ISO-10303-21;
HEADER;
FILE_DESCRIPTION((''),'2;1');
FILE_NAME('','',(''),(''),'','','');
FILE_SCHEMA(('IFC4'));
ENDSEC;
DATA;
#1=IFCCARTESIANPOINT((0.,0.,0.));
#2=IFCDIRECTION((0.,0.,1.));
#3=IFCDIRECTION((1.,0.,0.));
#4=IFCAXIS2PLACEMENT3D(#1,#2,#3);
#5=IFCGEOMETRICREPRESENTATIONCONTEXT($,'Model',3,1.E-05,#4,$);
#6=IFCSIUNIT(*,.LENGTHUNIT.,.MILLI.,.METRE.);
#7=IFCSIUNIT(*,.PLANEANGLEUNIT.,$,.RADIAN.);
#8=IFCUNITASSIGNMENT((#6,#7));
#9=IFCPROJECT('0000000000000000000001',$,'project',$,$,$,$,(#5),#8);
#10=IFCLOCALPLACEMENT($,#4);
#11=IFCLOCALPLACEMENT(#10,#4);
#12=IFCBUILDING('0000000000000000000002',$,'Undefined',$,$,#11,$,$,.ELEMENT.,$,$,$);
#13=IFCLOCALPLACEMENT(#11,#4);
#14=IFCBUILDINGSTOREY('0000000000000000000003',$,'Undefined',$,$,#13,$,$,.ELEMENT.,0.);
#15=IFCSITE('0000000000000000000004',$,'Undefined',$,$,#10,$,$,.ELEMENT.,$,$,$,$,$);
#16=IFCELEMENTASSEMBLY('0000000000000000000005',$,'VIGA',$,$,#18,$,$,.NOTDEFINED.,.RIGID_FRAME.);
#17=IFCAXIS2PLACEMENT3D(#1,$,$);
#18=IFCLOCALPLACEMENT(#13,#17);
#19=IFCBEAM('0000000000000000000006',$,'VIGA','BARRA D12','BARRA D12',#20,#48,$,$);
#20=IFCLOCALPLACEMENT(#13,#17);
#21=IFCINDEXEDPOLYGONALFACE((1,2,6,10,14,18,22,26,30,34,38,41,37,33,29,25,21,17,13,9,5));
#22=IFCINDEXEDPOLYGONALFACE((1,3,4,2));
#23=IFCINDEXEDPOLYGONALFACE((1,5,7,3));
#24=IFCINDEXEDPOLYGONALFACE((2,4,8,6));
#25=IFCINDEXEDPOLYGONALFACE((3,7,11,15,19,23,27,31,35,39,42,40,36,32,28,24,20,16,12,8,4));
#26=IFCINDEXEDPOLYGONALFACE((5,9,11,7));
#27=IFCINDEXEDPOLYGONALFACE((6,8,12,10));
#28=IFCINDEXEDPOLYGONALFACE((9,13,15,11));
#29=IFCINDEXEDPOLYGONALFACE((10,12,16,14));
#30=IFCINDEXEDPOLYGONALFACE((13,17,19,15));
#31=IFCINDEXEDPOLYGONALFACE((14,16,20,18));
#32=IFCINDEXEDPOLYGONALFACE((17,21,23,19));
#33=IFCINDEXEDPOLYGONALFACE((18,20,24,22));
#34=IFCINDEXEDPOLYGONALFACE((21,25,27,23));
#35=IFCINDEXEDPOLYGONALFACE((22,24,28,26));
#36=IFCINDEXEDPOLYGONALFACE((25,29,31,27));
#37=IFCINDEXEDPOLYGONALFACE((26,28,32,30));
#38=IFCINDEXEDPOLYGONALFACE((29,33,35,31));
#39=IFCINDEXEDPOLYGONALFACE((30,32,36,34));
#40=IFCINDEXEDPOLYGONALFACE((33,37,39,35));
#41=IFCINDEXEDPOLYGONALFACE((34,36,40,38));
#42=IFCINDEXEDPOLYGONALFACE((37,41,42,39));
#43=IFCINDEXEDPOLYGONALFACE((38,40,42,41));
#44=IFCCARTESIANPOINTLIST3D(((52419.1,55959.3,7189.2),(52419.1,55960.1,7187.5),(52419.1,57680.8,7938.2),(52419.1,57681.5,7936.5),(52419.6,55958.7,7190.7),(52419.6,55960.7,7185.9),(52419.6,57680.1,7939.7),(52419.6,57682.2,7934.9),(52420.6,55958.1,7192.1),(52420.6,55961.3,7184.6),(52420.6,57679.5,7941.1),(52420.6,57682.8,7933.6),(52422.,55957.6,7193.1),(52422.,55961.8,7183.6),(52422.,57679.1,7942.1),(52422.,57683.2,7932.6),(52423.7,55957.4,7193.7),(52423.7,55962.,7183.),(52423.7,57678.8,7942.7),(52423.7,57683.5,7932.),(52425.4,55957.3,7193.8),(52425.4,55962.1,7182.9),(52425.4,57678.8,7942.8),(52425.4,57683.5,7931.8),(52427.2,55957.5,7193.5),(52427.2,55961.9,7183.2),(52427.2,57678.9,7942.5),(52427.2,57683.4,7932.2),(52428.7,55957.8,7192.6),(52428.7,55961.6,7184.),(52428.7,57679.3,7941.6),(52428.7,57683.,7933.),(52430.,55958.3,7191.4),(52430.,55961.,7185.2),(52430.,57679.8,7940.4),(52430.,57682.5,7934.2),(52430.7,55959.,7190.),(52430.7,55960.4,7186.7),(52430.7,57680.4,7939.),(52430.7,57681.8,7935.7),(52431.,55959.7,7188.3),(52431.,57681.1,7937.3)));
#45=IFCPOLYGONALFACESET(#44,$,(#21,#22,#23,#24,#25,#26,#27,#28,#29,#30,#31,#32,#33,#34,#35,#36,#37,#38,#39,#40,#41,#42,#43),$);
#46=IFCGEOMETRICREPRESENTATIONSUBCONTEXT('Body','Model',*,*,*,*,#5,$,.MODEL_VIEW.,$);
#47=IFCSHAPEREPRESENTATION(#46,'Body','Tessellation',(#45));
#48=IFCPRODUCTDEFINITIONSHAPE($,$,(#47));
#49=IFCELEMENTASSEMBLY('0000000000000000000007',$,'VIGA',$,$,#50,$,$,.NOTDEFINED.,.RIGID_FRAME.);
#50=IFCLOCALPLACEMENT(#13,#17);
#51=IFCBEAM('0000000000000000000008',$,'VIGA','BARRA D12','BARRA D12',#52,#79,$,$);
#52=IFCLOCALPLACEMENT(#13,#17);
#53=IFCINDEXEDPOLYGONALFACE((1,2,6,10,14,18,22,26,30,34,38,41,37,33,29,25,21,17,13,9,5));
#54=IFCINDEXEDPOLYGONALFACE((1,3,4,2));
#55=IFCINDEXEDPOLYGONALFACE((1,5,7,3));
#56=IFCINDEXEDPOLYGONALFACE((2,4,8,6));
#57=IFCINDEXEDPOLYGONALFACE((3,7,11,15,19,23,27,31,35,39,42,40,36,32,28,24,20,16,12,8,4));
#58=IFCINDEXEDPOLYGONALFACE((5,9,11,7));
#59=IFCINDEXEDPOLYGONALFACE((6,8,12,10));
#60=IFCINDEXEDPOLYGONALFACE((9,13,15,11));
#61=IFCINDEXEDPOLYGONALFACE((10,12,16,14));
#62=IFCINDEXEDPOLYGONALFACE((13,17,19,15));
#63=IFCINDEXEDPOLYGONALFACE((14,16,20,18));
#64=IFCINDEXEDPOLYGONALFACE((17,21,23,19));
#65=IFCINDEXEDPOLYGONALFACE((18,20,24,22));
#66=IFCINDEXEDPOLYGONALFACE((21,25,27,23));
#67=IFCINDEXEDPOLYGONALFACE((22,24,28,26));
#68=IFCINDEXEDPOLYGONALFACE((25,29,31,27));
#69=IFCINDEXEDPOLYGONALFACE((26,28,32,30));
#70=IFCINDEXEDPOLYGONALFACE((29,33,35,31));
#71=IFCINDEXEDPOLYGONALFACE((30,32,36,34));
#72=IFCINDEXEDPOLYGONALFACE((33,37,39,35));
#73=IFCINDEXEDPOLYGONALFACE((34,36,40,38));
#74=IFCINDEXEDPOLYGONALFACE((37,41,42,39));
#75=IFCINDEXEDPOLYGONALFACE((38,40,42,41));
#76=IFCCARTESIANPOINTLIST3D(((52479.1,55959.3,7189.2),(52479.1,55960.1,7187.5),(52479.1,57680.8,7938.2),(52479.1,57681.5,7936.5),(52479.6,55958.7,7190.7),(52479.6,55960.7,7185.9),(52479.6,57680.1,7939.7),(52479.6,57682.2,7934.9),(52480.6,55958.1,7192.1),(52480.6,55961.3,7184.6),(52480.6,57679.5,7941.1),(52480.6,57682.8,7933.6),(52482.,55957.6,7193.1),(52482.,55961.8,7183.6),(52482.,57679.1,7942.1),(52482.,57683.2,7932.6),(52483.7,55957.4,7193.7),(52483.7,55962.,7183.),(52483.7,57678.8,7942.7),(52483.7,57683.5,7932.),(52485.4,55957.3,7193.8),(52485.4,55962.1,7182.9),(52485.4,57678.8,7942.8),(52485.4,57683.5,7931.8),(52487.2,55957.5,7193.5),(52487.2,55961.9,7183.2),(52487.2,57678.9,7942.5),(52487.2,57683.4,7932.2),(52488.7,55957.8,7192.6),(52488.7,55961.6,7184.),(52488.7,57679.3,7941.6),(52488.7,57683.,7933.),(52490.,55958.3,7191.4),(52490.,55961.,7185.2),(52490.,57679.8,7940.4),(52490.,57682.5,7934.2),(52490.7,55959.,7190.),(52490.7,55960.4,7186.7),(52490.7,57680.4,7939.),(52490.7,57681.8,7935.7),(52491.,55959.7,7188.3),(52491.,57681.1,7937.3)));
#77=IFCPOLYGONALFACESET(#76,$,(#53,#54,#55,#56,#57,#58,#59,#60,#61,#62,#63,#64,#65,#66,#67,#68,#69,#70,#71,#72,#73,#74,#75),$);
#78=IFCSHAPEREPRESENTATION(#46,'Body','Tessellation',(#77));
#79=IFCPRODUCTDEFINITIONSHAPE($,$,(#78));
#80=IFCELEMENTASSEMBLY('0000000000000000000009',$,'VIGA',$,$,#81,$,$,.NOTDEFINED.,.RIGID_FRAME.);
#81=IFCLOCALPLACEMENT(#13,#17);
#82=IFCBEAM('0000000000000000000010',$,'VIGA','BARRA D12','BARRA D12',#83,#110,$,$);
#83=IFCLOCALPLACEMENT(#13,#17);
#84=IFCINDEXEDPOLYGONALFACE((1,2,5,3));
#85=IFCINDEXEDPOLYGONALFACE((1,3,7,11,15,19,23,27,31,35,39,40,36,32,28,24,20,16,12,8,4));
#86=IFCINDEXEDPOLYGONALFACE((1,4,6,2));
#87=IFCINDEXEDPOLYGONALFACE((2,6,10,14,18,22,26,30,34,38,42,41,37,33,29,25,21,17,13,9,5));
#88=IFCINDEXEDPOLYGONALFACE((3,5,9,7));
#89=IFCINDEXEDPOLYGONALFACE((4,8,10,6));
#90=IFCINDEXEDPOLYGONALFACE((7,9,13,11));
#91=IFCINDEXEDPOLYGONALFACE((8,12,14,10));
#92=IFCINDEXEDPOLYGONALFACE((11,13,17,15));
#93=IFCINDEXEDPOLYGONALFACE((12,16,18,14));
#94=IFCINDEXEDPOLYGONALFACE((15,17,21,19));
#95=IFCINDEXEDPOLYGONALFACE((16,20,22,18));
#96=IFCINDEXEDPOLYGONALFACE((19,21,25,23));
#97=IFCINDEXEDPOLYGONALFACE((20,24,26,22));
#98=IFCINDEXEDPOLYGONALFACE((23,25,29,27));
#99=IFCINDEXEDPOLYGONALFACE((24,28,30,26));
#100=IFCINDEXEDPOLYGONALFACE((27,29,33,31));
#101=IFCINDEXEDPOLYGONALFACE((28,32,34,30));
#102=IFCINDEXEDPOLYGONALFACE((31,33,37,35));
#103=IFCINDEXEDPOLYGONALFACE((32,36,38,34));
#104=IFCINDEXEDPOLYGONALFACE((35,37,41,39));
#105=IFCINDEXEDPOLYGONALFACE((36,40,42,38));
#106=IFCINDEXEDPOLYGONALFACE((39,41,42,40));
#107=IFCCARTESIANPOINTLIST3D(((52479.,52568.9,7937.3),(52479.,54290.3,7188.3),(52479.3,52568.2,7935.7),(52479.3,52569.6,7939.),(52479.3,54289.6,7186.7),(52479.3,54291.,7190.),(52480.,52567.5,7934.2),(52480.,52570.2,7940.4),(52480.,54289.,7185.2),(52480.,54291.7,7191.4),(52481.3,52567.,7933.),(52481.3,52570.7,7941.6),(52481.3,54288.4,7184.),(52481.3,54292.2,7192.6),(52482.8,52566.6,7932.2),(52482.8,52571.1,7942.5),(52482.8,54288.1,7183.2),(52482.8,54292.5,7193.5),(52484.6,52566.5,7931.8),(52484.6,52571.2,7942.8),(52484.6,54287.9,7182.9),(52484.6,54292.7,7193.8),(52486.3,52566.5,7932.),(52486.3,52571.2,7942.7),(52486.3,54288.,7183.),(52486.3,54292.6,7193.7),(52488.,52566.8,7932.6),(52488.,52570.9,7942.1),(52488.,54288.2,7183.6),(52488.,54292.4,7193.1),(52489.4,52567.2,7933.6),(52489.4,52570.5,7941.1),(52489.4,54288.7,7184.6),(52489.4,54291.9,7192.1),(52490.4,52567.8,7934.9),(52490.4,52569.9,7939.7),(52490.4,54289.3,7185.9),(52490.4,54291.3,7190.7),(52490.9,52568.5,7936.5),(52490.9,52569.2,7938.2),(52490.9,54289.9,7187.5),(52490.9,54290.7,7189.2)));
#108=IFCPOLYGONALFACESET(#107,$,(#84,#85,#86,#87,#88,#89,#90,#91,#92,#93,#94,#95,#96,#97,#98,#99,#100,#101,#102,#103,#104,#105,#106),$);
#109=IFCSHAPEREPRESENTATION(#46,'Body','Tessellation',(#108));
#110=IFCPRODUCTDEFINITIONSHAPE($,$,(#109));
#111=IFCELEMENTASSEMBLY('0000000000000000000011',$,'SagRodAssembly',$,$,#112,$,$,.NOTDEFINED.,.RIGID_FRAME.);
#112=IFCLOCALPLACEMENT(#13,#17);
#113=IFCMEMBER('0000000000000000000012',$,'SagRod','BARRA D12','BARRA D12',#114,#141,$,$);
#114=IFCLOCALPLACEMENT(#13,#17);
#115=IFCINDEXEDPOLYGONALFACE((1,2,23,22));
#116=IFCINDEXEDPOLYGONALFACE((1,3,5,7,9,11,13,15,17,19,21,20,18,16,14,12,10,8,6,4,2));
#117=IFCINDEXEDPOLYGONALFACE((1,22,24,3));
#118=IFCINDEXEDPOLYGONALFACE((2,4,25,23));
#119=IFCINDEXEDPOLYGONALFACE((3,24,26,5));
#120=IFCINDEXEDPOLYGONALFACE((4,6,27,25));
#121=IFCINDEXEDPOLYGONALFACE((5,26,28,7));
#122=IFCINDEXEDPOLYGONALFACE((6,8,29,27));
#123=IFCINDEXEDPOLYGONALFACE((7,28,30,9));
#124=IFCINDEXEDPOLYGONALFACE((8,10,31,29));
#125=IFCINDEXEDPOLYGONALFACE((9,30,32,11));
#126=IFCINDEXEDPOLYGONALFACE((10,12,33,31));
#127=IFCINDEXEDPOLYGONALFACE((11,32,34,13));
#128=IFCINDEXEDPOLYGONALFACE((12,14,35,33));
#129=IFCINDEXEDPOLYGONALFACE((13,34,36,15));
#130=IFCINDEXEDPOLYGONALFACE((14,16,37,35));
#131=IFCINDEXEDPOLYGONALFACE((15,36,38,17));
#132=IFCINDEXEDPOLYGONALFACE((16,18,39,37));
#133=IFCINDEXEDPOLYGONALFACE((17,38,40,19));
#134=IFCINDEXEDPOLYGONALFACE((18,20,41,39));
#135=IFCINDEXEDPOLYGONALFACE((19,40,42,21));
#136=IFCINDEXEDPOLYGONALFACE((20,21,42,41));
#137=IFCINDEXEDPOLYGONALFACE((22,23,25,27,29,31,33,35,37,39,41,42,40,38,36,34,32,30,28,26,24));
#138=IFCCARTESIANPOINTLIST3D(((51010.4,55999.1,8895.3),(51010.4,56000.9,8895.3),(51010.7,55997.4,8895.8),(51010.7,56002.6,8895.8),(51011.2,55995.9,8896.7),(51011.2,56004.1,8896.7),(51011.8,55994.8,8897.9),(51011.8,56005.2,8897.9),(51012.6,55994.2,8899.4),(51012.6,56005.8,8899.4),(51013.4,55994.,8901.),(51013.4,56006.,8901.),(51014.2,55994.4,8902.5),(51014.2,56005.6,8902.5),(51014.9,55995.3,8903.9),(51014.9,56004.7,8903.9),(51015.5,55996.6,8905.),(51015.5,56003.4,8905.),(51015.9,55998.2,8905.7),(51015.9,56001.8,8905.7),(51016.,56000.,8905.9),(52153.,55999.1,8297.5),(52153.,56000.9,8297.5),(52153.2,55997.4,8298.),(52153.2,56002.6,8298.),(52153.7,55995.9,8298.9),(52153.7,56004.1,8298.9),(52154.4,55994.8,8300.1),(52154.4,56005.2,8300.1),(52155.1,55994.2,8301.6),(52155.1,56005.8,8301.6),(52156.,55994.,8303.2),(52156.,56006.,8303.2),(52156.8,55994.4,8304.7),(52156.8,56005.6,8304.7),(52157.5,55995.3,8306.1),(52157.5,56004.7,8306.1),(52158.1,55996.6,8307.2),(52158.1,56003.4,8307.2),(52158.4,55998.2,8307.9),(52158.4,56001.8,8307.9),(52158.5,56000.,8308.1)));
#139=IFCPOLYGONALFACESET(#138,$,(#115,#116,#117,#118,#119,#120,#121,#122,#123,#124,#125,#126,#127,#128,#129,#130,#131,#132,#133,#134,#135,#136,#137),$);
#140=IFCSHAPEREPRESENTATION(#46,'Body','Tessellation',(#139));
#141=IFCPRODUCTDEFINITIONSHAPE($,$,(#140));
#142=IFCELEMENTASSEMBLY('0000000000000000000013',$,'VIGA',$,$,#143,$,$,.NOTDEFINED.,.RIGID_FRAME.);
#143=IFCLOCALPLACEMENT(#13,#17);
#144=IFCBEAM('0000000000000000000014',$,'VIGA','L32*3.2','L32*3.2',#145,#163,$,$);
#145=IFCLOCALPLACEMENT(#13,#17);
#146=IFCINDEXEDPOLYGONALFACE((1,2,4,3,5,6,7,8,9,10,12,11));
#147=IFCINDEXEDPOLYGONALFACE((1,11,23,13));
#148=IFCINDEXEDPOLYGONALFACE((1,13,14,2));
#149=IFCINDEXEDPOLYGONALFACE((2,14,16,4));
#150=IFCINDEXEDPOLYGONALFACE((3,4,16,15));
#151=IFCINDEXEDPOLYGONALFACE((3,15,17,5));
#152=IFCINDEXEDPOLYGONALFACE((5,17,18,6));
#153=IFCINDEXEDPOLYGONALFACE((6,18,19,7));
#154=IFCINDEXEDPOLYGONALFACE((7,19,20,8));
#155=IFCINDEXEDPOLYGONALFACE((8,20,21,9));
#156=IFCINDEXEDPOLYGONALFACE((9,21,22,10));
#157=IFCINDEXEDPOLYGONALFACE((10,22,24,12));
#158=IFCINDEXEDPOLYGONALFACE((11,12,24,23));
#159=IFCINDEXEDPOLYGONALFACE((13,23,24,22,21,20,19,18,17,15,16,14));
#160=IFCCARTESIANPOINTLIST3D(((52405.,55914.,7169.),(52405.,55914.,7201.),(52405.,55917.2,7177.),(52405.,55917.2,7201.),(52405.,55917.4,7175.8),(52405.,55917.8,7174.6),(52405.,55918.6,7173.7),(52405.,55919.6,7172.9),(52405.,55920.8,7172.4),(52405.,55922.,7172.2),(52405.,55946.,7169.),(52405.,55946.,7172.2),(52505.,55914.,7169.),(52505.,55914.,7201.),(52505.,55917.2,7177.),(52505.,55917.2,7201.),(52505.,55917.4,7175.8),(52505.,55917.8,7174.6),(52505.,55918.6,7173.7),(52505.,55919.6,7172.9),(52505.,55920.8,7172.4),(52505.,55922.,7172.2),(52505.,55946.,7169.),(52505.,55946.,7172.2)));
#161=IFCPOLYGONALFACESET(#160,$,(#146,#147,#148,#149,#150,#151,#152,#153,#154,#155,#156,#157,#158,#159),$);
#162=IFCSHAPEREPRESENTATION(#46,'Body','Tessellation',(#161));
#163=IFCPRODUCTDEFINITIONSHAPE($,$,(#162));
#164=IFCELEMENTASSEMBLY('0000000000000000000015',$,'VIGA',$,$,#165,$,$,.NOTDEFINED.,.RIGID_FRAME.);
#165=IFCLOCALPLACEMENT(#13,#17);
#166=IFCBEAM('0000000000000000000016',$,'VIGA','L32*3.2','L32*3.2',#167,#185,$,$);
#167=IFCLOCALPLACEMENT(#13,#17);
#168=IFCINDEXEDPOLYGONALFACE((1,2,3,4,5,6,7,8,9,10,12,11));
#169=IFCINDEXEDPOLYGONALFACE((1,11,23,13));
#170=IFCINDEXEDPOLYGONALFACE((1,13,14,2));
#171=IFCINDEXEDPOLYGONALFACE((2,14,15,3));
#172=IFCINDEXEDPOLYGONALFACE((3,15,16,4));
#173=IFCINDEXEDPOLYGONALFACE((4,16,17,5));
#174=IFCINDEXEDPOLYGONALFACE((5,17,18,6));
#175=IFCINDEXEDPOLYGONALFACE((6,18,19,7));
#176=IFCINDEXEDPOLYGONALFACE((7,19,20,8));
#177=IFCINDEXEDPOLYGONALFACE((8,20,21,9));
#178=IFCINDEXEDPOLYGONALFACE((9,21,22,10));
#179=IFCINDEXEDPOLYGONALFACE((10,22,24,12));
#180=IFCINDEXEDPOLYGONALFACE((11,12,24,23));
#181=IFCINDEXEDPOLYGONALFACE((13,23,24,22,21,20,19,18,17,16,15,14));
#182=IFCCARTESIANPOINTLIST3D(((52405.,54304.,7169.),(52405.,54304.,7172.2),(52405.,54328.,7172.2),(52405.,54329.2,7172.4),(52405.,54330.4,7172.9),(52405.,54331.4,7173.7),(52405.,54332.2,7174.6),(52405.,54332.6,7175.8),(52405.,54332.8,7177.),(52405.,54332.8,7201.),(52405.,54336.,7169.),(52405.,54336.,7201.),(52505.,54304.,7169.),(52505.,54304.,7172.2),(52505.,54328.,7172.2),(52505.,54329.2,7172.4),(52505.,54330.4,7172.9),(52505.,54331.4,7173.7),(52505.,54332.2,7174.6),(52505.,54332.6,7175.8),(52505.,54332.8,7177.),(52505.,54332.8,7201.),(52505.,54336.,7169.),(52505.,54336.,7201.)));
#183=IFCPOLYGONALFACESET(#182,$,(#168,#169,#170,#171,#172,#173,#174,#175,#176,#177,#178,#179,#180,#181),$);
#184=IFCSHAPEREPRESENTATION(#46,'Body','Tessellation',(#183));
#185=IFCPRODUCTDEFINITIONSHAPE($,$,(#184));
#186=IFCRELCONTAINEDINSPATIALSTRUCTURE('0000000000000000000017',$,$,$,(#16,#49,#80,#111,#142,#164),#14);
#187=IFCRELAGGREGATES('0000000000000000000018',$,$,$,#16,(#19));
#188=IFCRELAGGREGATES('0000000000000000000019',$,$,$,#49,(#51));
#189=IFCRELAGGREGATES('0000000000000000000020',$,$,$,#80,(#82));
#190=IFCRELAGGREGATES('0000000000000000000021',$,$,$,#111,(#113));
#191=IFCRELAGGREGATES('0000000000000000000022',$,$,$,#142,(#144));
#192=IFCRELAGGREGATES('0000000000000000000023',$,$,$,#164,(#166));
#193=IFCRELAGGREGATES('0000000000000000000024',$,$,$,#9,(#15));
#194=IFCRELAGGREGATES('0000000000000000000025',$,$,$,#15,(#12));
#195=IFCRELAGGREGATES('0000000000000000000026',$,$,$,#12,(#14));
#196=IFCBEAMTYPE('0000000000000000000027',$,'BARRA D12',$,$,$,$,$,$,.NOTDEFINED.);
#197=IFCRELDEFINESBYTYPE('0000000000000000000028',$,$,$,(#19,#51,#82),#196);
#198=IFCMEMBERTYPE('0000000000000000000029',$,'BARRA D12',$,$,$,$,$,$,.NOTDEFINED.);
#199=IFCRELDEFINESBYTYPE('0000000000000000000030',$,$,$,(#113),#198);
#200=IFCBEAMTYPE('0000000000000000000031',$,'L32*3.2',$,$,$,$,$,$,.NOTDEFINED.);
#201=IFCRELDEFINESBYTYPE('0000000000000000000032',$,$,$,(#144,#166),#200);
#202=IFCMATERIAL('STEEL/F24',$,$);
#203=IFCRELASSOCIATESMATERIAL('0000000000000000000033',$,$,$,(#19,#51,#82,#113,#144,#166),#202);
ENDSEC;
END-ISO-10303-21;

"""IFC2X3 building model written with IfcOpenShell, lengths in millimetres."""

from ifc_helpers import new_model, si_unit, frame, origin_with_axes, origin_2d_with_axis, place, context, subcontext, project, spatial, circle, l_section, extrude, material, type_object, element, aggregate, save


model = new_model("IFC2X3")

# Units and contexts
model_context = context("Model", 3, precision=1e-05, world=origin_with_axes())
body_context = subcontext(model_context, "Body", "Model", "MODEL_VIEW")
ifc_project = project(units=[si_unit("LENGTHUNIT", "METRE", prefix="MILLI"), si_unit("PLANEANGLEUNIT", "RADIAN")], contexts=[model_context])

# Site, building, storey
site_placement = place(None, origin_with_axes())
site = spatial("IfcSite", under=ifc_project, at=site_placement, Name="Undefined", CompositionType="ELEMENT")
building_placement = place(site_placement, origin_with_axes())
building = spatial("IfcBuilding", under=site, at=building_placement, Name="Undefined", CompositionType="ELEMENT")
storey_placement = place(building_placement, origin_with_axes())
storey = spatial("IfcBuildingStorey", under=building, at=storey_placement, Name="Undefined", CompositionType="ELEMENT", Elevation=0.0)

# Element assemblies, beams
assembly_1_placement = place(storey_placement, origin_with_axes())
assembly_1 = element("IfcElementAssembly", 1, at=assembly_1_placement, inside=storey, Name="VIGA", AssemblyPlace="NOTDEFINED", PredefinedType="RIGID_FRAME")
ifc_material_1 = material(Name="STEEL/F24")
beam_type_1 = type_object("IfcBeamType", Name="BARRA D12", PredefinedType="NOTDEFINED")
beam_1_placement = place(assembly_1_placement, frame((52425.0, 55959.7, 7188.3), z_axis=(0.0, -0.39897, 0.916964), x_axis=(0.0, 0.916964, 0.39897)))
beam_1 = element("IfcBeam", 2, at=beam_1_placement, type_object=beam_type_1, material=ifc_material_1, Name="VIGA", Description="BARRA D12", ObjectType="BARRA D12", context=body_context, shape_type="SweptSolid", body=[
    extrude(circle(Radius=6.0, at=origin_2d_with_axis()), frame((1877.3, 0.0, 0.0), z_axis=(-1.0, 0.0, 0.0), x_axis=(0.0, -1.0, 0.0)), (0.0, 0.0, 1.0), 1877.3),
])
aggregate(assembly_1, [beam_1])
assembly_2_placement = place(storey_placement, origin_with_axes())
assembly_2 = element("IfcElementAssembly", 3, at=assembly_2_placement, inside=storey, Name="VIGA", AssemblyPlace="NOTDEFINED", PredefinedType="RIGID_FRAME")
beam_2_placement = place(assembly_2_placement, frame((52485.0, 55959.7, 7188.3), z_axis=(0.0, -0.39897, 0.916964), x_axis=(0.0, 0.916964, 0.39897)))
beam_2 = element("IfcBeam", 4, at=beam_2_placement, type_object=beam_type_1, material=ifc_material_1, Name="VIGA", Description="BARRA D12", ObjectType="BARRA D12", context=body_context, shape_type="SweptSolid", body=[
    extrude(circle(Radius=6.0, at=origin_2d_with_axis()), frame((1877.3, 0.0, 0.0), z_axis=(-1.0, 0.0, 0.0), x_axis=(0.0, -1.0, 0.0)), (0.0, 0.0, 1.0), 1877.3),
])
aggregate(assembly_2, [beam_2])
assembly_3_placement = place(storey_placement, origin_with_axes())
assembly_3 = element("IfcElementAssembly", 5, at=assembly_3_placement, inside=storey, Name="VIGA", AssemblyPlace="NOTDEFINED", PredefinedType="RIGID_FRAME")
beam_3_placement = place(assembly_3_placement, frame((52485.0, 54290.3, 7188.3), z_axis=(0.0, 0.39897, 0.916964), x_axis=(0.0, -0.916964, 0.39897)))
beam_3 = element("IfcBeam", 6, at=beam_3_placement, type_object=beam_type_1, material=ifc_material_1, Name="VIGA", Description="BARRA D12", ObjectType="BARRA D12", context=body_context, shape_type="SweptSolid", body=[
    extrude(circle(Radius=6.0, at=origin_2d_with_axis()), frame((1877.3, 0.0, 0.0), z_axis=(-1.0, 0.0, 0.0), x_axis=(0.0, -1.0, 0.0)), (0.0, 0.0, 1.0), 1877.3),
])
aggregate(assembly_3, [beam_3])

# Element assembly, member
assembly_4_placement = place(storey_placement, origin_with_axes())
assembly_4 = element("IfcElementAssembly", 7, at=assembly_4_placement, inside=storey, Name="SagRodAssembly", AssemblyPlace="NOTDEFINED", PredefinedType="RIGID_FRAME")
member_type = type_object("IfcMemberType", Name="BARRA D12", PredefinedType="NOTDEFINED")
member_placement = place(assembly_4_placement, frame((52155.8, 56000.0, 8302.8), z_axis=(0.0, -1.0, 0.0), x_axis=(-0.886056, 0.0, 0.463578)))
member = element("IfcMember", 8, at=member_placement, type_object=member_type, material=ifc_material_1, Name="SagRod", Description="BARRA D12", ObjectType="BARRA D12", context=body_context, shape_type="SweptSolid", body=[
    extrude(circle(Radius=6.0, at=origin_2d_with_axis()), frame((1289.5, 0.0, 0.0), z_axis=(-1.0, 0.0, 0.0), x_axis=(0.0, -1.0, 0.0)), (0.0, 0.0, 1.0), 1289.5),
])

# Element assemblies, beams
assembly_5_placement = place(storey_placement, origin_with_axes())
assembly_5 = element("IfcElementAssembly", 9, at=assembly_5_placement, inside=storey, Name="VIGA", AssemblyPlace="NOTDEFINED", PredefinedType="RIGID_FRAME")
beam_type_2 = type_object("IfcBeamType", Name="L32*3.2", PredefinedType="NOTDEFINED")
beam_4_placement = place(assembly_5_placement, frame((52505.0, 55930.0, 7185.0), z_axis=(0.0, 0.0, 1.0), x_axis=(-1.0, 0.0, 0.0)))
beam_4 = element("IfcBeam", 10, at=beam_4_placement, type_object=beam_type_2, material=ifc_material_1, Name="VIGA", Description="L32*3.2", ObjectType="L32*3.2", context=body_context, shape_type="SweptSolid", body=[
    extrude(l_section(Depth=32.0, Width=32.0, Thickness=3.2, FilletRadius=4.8, at=origin_2d_with_axis()), frame((100.0, 0.0, 0.0), z_axis=(-1.0, 0.0, 0.0), x_axis=(0.0, -1.0, 0.0)), (0.0, 0.0, 1.0), 100.0),
])
assembly_6_placement = place(storey_placement, origin_with_axes())
assembly_6 = element("IfcElementAssembly", 11, at=assembly_6_placement, inside=storey, Name="VIGA", AssemblyPlace="NOTDEFINED", PredefinedType="RIGID_FRAME")
beam_5_placement = place(assembly_6_placement, frame((52405.0, 54320.0, 7185.0), z_axis=(0.0, 0.0, 1.0), x_axis=(1.0, 0.0, 0.0)))
beam_5 = element("IfcBeam", 12, at=beam_5_placement, type_object=beam_type_2, material=ifc_material_1, Name="VIGA", Description="L32*3.2", ObjectType="L32*3.2", context=body_context, shape_type="SweptSolid", body=[
    extrude(l_section(Depth=32.0, Width=32.0, Thickness=3.2, FilletRadius=4.8, at=origin_2d_with_axis()), frame((100.0, 0.0, 0.0), z_axis=(-1.0, 0.0, 0.0), x_axis=(0.0, -1.0, 0.0)), (0.0, 0.0, 1.0), 100.0),
])

aggregate(assembly_4, [member])

aggregate(assembly_5, [beam_4])
aggregate(assembly_6, [beam_5])

save(model, "model.ifc")
